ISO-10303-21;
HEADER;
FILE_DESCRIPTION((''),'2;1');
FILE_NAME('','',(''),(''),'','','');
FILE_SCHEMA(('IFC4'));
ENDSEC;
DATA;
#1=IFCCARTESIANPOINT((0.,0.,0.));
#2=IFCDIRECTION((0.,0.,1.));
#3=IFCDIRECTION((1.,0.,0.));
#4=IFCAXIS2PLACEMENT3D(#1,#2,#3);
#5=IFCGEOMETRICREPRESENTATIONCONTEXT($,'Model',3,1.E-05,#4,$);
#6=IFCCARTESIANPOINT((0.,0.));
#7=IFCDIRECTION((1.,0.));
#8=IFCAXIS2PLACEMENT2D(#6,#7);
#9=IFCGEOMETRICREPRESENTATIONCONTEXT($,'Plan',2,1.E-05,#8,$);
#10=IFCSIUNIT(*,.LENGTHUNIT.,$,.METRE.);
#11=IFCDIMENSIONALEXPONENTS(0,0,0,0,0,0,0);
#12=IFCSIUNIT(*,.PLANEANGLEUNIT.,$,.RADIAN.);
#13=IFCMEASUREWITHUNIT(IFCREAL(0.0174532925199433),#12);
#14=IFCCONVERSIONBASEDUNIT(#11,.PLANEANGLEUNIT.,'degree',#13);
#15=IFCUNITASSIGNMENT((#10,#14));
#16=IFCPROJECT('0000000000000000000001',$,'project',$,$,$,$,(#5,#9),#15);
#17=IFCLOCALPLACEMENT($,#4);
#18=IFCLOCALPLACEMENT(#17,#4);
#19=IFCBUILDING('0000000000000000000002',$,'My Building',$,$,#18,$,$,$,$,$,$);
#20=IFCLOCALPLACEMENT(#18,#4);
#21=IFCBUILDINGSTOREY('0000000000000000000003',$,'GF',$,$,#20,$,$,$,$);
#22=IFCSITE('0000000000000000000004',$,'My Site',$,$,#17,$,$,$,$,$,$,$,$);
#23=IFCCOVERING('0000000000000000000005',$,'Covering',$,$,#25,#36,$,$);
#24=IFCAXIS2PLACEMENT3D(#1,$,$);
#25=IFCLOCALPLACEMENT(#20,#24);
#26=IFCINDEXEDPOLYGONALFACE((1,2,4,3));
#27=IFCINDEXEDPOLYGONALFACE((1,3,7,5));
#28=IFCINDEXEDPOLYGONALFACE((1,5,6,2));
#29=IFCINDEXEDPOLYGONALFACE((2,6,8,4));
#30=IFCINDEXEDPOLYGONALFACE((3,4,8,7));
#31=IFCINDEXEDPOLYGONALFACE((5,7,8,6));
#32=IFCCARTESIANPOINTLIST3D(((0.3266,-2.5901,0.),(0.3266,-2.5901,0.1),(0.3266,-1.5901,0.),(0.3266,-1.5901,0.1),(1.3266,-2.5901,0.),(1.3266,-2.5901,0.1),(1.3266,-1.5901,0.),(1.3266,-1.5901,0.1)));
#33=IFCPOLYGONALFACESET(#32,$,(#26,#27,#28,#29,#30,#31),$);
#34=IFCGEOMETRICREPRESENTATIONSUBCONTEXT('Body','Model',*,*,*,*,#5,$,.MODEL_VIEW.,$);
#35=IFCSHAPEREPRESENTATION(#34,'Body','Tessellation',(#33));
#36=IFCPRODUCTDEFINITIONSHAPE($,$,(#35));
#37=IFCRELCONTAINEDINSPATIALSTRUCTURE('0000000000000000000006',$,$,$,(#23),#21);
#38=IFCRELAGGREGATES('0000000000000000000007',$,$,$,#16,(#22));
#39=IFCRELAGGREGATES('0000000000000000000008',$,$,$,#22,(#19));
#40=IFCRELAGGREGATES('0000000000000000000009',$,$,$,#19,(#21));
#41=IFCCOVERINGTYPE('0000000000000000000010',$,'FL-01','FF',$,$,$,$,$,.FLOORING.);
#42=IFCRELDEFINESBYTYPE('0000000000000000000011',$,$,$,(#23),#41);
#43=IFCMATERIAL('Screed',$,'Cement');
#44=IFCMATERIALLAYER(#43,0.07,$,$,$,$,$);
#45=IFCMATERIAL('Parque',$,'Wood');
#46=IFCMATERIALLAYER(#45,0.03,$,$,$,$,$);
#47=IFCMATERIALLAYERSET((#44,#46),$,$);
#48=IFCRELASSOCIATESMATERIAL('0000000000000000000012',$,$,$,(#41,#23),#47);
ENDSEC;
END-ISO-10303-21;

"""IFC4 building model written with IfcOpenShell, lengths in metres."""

from ifc_helpers import new_model, entity, si_unit, converted_unit, frame, origin_with_axes, origin_2d_with_axis, place, context, subcontext, project, spatial, indexed_curve, outline, extrude, material, layer, layer_set, layer_usage, type_object, element, save


model = new_model("IFC4")

# Units and contexts
model_context = context("Model", 3, precision=1e-05, world=origin_with_axes())
plan_context = context("Plan", 2, precision=1e-05, world=origin_2d_with_axis())
body_context_1 = subcontext(model_context, "Body", "Model", "MODEL_VIEW")
ifc_project = project(units=[si_unit("LENGTHUNIT", "METRE"), converted_unit("PLANEANGLEUNIT", "degree", entity("IfcReal", 0.0174532925199433), si_unit("PLANEANGLEUNIT", "RADIAN"), dimensions=[0, 0, 0, 0, 0, 0, 0])], contexts=[model_context, plan_context])

# Site, building, storey
site_placement = place(None, origin_with_axes())
site = spatial("IfcSite", under=ifc_project, at=site_placement, Name="My Site")
building_placement = place(site_placement, origin_with_axes())
building = spatial("IfcBuilding", under=site, at=building_placement, Name="My Building")
storey_placement = place(building_placement, origin_with_axes())
storey = spatial("IfcBuildingStorey", under=building, at=storey_placement, Name="GF")

# Covering
ifc_material_1 = material(Name="Screed", Category="Cement")
ifc_layer_1 = layer(ifc_material_1, 0.07)
ifc_material_2 = material(Name="Parque", Category="Wood")
ifc_layer_2 = layer(ifc_material_2, 0.03)
ifc_layer_set_1 = layer_set([ifc_layer_1, ifc_layer_2])
ifc_layer_usage_1 = layer_usage(ifc_layer_set_1, "AXIS3", "POSITIVE", 0.0)
covering_type = type_object("IfcCoveringType", Name="FL-01", Description="FF", PredefinedType="FLOORING", material=ifc_layer_set_1)
covering_placement = place(storey_placement, frame((0.3266, -2.5901, 0.0), z_axis=(0.0, 0.0, 1.0), x_axis=(1.0, 0.0, 0.0)))
element("IfcCovering", 1, at=covering_placement, inside=storey, type_object=covering_type, material=ifc_layer_usage_1, Name="Covering", context=body_context_1, shape_type="SweptSolid", body=[
    extrude(outline(indexed_curve([(0.0, 0.0), (1.0, 0.0), (1.0, 1.0), (0.0, 1.0), (0.0, 0.0)])), None, (0.0, 0.0, 1.0), 0.1),
])

save(model, "model.ifc")
